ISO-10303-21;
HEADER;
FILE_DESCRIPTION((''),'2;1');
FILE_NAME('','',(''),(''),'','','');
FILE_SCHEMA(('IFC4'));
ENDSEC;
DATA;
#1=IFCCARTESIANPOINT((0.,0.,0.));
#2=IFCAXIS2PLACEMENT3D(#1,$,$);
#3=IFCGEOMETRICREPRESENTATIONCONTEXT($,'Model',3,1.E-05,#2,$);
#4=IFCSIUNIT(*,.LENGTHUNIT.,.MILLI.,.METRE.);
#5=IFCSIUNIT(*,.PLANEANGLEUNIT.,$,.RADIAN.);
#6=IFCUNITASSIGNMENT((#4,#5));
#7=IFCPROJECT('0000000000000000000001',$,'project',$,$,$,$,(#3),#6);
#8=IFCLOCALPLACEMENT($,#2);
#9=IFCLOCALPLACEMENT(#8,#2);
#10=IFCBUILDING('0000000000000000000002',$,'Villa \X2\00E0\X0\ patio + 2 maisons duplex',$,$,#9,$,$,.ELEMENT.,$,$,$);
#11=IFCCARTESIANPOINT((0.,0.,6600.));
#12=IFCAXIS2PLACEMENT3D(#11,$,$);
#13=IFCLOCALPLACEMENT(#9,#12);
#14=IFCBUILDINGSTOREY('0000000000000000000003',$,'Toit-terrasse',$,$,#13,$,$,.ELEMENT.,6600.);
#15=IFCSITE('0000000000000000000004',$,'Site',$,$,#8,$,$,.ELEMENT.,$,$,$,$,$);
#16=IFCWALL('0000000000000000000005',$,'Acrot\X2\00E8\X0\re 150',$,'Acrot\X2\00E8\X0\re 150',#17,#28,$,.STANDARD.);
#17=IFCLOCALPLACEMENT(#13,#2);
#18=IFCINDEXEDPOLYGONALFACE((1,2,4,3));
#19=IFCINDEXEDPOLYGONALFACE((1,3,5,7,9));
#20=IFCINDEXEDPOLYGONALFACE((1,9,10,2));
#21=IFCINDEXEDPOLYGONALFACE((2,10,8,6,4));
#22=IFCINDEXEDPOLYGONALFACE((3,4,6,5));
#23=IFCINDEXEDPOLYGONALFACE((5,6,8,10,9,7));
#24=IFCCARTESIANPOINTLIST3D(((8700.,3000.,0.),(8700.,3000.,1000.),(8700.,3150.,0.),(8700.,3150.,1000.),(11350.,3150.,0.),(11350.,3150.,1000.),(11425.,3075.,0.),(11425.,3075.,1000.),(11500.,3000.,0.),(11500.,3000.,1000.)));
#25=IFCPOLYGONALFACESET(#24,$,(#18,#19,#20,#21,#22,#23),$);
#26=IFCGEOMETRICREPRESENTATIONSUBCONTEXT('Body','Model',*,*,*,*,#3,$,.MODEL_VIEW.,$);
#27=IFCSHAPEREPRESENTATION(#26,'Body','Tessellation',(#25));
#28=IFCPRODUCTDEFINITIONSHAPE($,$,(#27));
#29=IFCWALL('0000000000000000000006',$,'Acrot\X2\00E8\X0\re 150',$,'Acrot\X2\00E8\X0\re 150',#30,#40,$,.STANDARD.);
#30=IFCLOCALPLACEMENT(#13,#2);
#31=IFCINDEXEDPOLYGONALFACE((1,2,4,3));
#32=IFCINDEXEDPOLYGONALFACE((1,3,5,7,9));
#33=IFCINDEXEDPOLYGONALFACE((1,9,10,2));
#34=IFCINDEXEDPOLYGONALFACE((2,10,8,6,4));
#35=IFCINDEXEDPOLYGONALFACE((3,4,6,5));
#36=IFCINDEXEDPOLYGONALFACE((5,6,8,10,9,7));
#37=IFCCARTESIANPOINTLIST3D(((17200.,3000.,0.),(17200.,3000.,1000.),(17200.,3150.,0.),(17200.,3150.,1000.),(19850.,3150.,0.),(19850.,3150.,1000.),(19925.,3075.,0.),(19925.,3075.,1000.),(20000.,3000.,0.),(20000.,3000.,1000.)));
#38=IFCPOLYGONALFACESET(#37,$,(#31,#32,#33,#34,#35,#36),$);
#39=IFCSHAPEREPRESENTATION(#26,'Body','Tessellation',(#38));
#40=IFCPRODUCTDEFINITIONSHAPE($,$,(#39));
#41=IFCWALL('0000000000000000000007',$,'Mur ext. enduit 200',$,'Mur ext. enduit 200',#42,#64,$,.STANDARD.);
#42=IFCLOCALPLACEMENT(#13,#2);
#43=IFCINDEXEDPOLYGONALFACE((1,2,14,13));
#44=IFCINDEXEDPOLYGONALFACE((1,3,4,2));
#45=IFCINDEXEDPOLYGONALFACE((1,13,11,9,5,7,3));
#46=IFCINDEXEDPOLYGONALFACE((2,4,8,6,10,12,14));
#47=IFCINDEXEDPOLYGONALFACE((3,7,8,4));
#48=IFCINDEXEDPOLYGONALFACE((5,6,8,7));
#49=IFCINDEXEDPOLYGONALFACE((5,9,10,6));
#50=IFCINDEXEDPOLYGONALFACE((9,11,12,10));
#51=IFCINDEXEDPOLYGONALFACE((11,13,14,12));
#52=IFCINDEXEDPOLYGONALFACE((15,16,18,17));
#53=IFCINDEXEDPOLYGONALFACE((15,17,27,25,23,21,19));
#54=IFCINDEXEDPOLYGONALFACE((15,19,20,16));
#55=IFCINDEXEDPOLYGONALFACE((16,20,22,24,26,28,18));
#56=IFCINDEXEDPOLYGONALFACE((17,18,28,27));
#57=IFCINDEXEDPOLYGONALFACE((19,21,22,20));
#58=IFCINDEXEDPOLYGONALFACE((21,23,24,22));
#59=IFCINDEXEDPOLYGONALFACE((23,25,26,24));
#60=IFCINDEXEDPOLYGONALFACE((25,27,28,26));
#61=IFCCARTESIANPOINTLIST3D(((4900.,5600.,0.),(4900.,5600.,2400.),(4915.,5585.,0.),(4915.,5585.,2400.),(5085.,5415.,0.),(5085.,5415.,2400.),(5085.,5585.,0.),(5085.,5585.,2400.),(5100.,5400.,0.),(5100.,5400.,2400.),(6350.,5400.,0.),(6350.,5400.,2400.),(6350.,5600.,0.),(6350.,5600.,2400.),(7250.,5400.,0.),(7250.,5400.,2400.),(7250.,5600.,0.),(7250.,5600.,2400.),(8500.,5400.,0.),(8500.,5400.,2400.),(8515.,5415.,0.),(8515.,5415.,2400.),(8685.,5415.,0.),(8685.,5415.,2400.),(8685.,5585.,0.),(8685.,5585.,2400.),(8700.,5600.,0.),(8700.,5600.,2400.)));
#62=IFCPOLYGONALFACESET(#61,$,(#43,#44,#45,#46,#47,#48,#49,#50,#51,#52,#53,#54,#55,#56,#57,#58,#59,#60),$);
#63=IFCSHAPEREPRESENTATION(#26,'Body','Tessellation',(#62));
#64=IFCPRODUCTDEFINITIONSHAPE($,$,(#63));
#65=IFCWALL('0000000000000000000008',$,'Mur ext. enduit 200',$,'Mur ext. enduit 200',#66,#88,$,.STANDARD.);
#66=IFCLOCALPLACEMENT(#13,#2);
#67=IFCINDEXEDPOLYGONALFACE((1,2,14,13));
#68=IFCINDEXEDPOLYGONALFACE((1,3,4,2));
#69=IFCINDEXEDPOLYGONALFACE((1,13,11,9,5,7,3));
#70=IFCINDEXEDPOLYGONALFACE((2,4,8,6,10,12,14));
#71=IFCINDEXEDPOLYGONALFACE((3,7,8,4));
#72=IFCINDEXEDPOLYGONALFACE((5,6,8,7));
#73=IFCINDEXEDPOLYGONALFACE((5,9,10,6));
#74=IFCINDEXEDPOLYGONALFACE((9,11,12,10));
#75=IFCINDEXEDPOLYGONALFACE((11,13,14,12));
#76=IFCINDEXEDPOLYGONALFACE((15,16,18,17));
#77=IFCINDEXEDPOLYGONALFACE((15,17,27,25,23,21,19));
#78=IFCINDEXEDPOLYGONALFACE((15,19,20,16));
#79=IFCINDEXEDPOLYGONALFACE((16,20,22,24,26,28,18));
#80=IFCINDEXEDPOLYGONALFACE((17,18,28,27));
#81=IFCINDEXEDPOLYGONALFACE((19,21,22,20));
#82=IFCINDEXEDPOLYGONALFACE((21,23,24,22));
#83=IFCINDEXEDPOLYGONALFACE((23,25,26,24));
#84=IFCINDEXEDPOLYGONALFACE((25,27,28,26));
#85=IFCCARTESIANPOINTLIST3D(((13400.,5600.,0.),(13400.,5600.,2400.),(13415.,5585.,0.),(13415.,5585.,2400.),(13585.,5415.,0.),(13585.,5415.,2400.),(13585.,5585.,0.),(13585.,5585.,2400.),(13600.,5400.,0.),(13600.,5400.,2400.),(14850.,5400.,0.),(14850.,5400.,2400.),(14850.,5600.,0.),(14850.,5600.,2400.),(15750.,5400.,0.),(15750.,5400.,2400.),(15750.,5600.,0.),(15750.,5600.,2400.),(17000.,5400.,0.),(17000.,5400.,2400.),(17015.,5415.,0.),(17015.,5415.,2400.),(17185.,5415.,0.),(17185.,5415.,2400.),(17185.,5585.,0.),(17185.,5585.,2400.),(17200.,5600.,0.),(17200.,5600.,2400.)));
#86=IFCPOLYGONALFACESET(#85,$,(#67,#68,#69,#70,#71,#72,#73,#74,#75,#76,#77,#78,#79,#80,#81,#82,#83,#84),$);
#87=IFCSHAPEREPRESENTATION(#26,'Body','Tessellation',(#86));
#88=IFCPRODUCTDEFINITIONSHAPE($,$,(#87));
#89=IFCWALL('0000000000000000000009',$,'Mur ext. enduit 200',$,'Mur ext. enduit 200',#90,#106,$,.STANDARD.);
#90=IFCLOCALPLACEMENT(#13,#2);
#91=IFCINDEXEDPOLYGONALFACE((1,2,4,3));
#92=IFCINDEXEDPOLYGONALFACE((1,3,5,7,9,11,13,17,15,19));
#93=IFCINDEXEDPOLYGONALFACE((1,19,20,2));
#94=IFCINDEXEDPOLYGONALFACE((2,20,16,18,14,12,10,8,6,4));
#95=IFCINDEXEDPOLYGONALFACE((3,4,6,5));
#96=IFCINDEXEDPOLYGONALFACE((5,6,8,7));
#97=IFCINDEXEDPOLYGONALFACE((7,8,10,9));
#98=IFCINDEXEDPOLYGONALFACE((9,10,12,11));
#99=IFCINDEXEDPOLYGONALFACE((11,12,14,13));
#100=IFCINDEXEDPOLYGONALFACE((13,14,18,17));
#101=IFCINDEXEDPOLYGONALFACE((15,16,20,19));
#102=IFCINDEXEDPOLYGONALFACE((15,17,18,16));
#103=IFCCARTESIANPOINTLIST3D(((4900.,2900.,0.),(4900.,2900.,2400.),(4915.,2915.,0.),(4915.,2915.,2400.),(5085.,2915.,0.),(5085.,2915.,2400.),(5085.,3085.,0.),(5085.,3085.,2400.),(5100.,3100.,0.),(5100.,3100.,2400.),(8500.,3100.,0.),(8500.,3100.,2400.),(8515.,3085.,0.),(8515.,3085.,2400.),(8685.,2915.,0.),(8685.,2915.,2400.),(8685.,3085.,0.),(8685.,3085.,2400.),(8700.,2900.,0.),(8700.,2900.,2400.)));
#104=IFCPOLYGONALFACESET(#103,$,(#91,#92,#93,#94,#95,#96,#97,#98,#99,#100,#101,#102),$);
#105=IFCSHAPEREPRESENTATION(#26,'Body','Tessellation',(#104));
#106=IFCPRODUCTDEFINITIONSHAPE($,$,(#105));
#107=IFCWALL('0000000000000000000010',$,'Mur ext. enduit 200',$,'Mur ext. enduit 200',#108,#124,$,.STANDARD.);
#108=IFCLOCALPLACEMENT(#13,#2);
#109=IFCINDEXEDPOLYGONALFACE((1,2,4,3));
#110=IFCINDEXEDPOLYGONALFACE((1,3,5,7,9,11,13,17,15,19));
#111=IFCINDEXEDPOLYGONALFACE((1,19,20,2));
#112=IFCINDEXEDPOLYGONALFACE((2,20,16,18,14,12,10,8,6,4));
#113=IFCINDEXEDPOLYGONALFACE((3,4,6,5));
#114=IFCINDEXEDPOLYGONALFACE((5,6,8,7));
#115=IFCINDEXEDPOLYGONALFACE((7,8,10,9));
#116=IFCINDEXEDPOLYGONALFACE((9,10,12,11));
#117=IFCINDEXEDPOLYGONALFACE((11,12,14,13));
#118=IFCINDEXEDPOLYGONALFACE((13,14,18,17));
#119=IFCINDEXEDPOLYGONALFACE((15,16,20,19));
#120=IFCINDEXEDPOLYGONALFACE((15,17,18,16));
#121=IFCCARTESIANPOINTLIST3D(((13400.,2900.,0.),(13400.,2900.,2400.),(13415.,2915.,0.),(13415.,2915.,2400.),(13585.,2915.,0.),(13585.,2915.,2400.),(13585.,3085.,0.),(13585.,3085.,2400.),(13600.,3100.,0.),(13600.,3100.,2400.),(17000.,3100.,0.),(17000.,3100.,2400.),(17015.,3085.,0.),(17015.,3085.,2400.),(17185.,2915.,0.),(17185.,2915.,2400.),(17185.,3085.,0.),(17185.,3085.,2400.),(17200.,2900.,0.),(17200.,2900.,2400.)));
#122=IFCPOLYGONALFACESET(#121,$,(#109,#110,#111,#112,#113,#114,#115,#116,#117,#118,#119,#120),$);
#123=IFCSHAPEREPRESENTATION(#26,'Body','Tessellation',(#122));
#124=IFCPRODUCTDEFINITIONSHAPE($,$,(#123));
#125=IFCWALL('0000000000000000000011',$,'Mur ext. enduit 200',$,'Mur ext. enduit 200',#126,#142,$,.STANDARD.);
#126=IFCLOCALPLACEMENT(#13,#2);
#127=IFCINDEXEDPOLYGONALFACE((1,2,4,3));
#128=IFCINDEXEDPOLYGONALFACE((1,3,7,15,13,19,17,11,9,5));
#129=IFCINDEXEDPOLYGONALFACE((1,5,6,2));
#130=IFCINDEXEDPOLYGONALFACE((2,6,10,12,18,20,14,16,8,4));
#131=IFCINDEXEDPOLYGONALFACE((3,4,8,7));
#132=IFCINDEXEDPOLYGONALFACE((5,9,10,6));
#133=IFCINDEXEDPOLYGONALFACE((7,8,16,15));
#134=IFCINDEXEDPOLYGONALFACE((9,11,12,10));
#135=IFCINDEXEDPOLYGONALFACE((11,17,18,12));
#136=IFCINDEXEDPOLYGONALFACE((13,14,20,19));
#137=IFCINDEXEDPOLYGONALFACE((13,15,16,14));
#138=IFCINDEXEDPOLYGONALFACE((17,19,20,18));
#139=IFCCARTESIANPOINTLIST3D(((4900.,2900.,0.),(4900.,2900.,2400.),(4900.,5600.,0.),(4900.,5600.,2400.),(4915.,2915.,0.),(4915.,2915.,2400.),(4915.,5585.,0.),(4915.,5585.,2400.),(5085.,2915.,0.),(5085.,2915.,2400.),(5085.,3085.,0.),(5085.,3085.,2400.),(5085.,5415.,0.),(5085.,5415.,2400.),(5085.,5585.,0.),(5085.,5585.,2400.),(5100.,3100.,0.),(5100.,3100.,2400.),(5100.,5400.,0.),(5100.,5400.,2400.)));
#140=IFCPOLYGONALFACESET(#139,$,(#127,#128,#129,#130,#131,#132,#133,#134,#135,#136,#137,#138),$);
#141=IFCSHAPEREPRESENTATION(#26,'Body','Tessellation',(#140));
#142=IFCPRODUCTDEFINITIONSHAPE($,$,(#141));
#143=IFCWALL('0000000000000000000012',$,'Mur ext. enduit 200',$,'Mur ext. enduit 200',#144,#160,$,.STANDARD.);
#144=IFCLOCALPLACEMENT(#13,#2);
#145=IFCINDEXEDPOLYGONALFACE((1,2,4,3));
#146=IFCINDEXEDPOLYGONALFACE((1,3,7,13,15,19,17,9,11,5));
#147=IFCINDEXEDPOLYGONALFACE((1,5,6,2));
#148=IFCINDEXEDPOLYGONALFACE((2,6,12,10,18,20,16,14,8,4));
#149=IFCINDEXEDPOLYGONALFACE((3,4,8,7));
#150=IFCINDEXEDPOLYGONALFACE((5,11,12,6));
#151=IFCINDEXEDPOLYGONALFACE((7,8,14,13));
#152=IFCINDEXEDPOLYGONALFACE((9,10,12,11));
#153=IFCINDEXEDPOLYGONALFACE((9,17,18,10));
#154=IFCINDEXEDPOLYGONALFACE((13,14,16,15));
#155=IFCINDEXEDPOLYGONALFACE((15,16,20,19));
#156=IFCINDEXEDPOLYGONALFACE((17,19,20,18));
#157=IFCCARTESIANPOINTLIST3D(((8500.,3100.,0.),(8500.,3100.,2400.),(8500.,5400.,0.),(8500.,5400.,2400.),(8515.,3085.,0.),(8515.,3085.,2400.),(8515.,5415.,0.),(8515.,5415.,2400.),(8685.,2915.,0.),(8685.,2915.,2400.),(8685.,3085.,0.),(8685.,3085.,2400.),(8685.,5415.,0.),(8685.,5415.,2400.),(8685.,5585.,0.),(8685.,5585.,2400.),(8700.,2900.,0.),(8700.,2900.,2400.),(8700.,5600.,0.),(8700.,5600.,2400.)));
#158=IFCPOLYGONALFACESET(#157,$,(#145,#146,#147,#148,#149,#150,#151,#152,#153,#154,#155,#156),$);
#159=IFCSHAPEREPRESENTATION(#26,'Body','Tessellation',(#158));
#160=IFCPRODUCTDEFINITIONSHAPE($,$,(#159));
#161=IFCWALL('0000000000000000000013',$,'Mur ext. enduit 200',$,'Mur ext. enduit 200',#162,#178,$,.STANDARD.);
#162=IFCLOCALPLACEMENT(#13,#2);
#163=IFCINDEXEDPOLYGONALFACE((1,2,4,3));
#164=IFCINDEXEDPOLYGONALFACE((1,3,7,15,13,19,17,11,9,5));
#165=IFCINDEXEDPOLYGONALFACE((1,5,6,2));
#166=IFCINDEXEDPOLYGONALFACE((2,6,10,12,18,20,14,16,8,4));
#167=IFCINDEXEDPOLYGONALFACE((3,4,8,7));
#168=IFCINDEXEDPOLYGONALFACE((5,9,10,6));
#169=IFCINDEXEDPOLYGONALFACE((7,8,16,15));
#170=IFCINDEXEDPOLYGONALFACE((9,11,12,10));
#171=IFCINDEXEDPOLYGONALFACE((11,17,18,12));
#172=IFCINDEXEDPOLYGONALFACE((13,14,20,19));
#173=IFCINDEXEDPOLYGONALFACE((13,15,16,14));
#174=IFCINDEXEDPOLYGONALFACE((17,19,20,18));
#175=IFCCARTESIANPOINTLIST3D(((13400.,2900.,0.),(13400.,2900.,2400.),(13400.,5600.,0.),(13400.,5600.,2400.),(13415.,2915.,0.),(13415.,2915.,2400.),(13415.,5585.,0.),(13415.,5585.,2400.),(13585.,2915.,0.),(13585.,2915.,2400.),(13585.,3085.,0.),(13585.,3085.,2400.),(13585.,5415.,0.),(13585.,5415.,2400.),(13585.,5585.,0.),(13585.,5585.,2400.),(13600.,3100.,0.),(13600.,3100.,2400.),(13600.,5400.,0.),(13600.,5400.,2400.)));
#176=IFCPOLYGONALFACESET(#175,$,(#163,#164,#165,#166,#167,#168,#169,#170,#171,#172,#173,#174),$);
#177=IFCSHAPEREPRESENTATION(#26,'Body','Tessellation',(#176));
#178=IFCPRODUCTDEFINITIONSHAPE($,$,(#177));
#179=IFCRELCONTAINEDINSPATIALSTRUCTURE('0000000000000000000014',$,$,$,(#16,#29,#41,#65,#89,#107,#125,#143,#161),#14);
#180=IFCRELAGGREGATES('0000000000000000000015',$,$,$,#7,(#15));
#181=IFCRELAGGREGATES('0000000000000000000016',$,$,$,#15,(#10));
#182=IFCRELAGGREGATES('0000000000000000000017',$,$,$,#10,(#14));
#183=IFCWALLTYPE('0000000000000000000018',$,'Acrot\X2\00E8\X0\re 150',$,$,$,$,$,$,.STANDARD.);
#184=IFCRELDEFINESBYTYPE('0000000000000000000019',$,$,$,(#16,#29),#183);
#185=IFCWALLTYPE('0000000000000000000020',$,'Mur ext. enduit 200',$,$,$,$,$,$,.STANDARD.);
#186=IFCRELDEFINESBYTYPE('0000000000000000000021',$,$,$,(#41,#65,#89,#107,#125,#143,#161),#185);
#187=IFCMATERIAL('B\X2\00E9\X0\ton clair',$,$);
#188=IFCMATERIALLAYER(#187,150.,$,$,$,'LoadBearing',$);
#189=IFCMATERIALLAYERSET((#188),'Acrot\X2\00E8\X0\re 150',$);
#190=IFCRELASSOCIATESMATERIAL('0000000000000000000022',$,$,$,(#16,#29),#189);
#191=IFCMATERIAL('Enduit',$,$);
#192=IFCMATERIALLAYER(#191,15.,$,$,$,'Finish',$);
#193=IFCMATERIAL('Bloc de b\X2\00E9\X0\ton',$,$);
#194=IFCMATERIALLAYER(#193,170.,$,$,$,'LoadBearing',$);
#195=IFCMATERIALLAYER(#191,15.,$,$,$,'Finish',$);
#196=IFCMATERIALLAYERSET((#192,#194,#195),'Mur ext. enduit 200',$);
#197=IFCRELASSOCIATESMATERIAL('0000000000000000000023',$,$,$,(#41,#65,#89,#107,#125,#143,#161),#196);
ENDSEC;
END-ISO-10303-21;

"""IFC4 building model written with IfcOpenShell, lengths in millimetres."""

from ifc_helpers import new_model, si_unit, frame, frame_2d, origin, place, context, subcontext, project, spatial, polyline, rectangle, outline, extrude, material, layer, layer_set, layer_usage, type_object, element, save


model = new_model("IFC4")

# Units and contexts
model_context = context("Model", 3, precision=1e-05, world=origin())
body_context = subcontext(model_context, "Body", "Model", "MODEL_VIEW")
ifc_project = project(units=[si_unit("LENGTHUNIT", "METRE", prefix="MILLI"), si_unit("PLANEANGLEUNIT", "RADIAN")], contexts=[model_context])

# Site, building, storey
site_placement = place(None, origin())
site = spatial("IfcSite", under=ifc_project, at=site_placement, Name="Site", CompositionType="ELEMENT")
building_placement = place(site_placement, origin())
building = spatial("IfcBuilding", under=site, at=building_placement, Name="Villa à patio + 2 maisons duplex", CompositionType="ELEMENT")
storey_placement = place(building_placement, frame((0.0, 0.0, 6600.0)))
storey = spatial("IfcBuildingStorey", under=building, at=storey_placement, Name="Toit-terrasse", CompositionType="ELEMENT", Elevation=6600.0)

# Walls
ifc_material_1 = material(Name="Béton clair")
ifc_layer_1 = layer(ifc_material_1, 150.0, Category="LoadBearing")
ifc_layer_set_1 = layer_set([ifc_layer_1], Name="Acrotère 150")
ifc_layer_usage_1 = layer_usage(ifc_layer_set_1, "AXIS2", "NEGATIVE", 75.0)
wall_type_1 = type_object("IfcWallType", Name="Acrotère 150", PredefinedType="STANDARD")
wall_1_placement = place(storey_placement, frame((11425.0, 3075.0, 0.0), z_axis=(0.0, 0.0, 1.0), x_axis=(-1.0, 0.0, 0.0)))
element("IfcWall", 1, at=wall_1_placement, inside=storey, type_object=wall_type_1, material=ifc_layer_usage_1, Name="Acrotère 150", ObjectType="Acrotère 150", PredefinedType="STANDARD", context=body_context, shape_type="SweptSolid", body=[
    extrude(outline(polyline([(75.0, -75.0), (0.0, 0.0), (-75.0, 75.0), (2725.0, 75.0), (2725.0, -75.0), (75.0, -75.0)])), origin(), (0.0, 0.0, 1.0), 1000.0),
])
wall_2_placement = place(storey_placement, frame((19925.0, 3075.0, 0.0), z_axis=(0.0, 0.0, 1.0), x_axis=(-1.0, 0.0, 0.0)))
element("IfcWall", 2, at=wall_2_placement, inside=storey, type_object=wall_type_1, material=ifc_layer_usage_1, Name="Acrotère 150", ObjectType="Acrotère 150", PredefinedType="STANDARD", context=body_context, shape_type="SweptSolid", body=[
    extrude(outline(polyline([(75.0, -75.0), (0.0, 0.0), (-75.0, 75.0), (2725.0, 75.0), (2725.0, -75.0), (75.0, -75.0)])), origin(), (0.0, 0.0, 1.0), 1000.0),
])

# Walls, openings
ifc_material_2 = material(Name="Enduit")
ifc_layer_2 = layer(ifc_material_2, 15.0, Category="Finish")
ifc_material_3 = material(Name="Bloc de béton")
ifc_layer_3 = layer(ifc_material_3, 170.0, Category="LoadBearing")
ifc_layer_4 = layer(ifc_material_2, 15.0, Category="Finish")
ifc_layer_set_2 = layer_set([ifc_layer_2, ifc_layer_3, ifc_layer_4], Name="Mur ext. enduit 200")
ifc_layer_usage_2 = layer_usage(ifc_layer_set_2, "AXIS2", "NEGATIVE", 100.0)
wall_type_2 = type_object("IfcWallType", Name="Mur ext. enduit 200", PredefinedType="STANDARD")
wall_3_placement = place(storey_placement, frame((5000.0, 5500.0, 0.0), z_axis=(0.0, 0.0, 1.0), x_axis=(1.0, 0.0, 0.0)))
wall_3 = element("IfcWall", 3, at=wall_3_placement, inside=storey, type_object=wall_type_2, material=ifc_layer_usage_2, Name="Mur ext. enduit 200", ObjectType="Mur ext. enduit 200", PredefinedType="STANDARD", context=body_context, shape_type="SweptSolid", body=[
    extrude(outline(polyline([(100.0, -100.0), (85.0, -85.0), (85.0, 85.0), (-85.0, 85.0), (-100.0, 100.0), (3700.0, 100.0), (3685.0, 85.0), (3685.0, -85.0), (3515.0, -85.0), (3500.0, -100.0), (100.0, -100.0)])), origin(), (0.0, 0.0, 1.0), 2400.0),
])
opening_1_placement = place(wall_3_placement, frame((1350.0, 0.0, 0.0), z_axis=(0.0, 0.0, 1.0), x_axis=(1.0, 0.0, 0.0)))
element("IfcOpeningElement", 4, at=opening_1_placement, cuts=wall_3, PredefinedType="OPENING", context=body_context, shape_type="SweptSolid", body=[
    extrude(rectangle(XDim=900.0, YDim=220.0, at=frame_2d((450.0, 0.0))), origin(), (0.0, 0.0, 1.0), 2400.0),
])
wall_4_placement = place(storey_placement, frame((13500.0, 5500.0, 0.0), z_axis=(0.0, 0.0, 1.0), x_axis=(1.0, 0.0, 0.0)))
wall_4 = element("IfcWall", 5, at=wall_4_placement, inside=storey, type_object=wall_type_2, material=ifc_layer_usage_2, Name="Mur ext. enduit 200", ObjectType="Mur ext. enduit 200", PredefinedType="STANDARD", context=body_context, shape_type="SweptSolid", body=[
    extrude(outline(polyline([(100.0, -100.0), (85.0, -85.0), (85.0, 85.0), (-85.0, 85.0), (-100.0, 100.0), (3700.0, 100.0), (3685.0, 85.0), (3685.0, -85.0), (3515.0, -85.0), (3500.0, -100.0), (100.0, -100.0)])), origin(), (0.0, 0.0, 1.0), 2400.0),
])
opening_2_placement = place(wall_4_placement, frame((1350.0, 0.0, 0.0), z_axis=(0.0, 0.0, 1.0), x_axis=(1.0, 0.0, 0.0)))
element("IfcOpeningElement", 6, at=opening_2_placement, cuts=wall_4, PredefinedType="OPENING", context=body_context, shape_type="SweptSolid", body=[
    extrude(rectangle(XDim=900.0, YDim=220.0, at=frame_2d((450.0, 0.0))), origin(), (0.0, 0.0, 1.0), 2400.0),
])

# Walls
for number, where, z_axis, x_axis, name in (
    (7, (5000.0, 3000.0, 0.0), (0.0, 0.0, 1.0), (1.0, 0.0, 0.0), "Mur ext. enduit 200"),
    (8, (13500.0, 3000.0, 0.0), (0.0, 0.0, 1.0), (1.0, 0.0, 0.0), "Mur ext. enduit 200"),
):
    element("IfcWall", number, at=place(storey_placement, frame(where, z_axis=z_axis, x_axis=x_axis)), inside=storey, type_object=wall_type_2, material=ifc_layer_usage_2, Name=name, ObjectType="Mur ext. enduit 200", PredefinedType="STANDARD", context=body_context, shape_type="SweptSolid", body=[
        extrude(outline(polyline([(-100.0, -100.0), (-85.0, -85.0), (85.0, -85.0), (85.0, 85.0), (100.0, 100.0), (3500.0, 100.0), (3515.0, 85.0), (3685.0, 85.0), (3685.0, -85.0), (3700.0, -100.0), (-100.0, -100.0)])), origin(), (0.0, 0.0, 1.0), 2400.0),
    ])
wall_5_placement = place(storey_placement, frame((5000.0, 5500.0, 0.0), z_axis=(0.0, 0.0, 1.0), x_axis=(0.0, -1.0, 0.0)))
element("IfcWall", 9, at=wall_5_placement, inside=storey, type_object=wall_type_2, material=ifc_layer_usage_2, Name="Mur ext. enduit 200", ObjectType="Mur ext. enduit 200", PredefinedType="STANDARD", context=body_context, shape_type="SweptSolid", body=[
    extrude(outline(polyline([(-100.0, -100.0), (-85.0, -85.0), (-85.0, 85.0), (85.0, 85.0), (100.0, 100.0), (2400.0, 100.0), (2415.0, 85.0), (2585.0, 85.0), (2585.0, -85.0), (2600.0, -100.0), (-100.0, -100.0)])), origin(), (0.0, 0.0, 1.0), 2400.0),
])
wall_6_placement = place(storey_placement, frame((8600.0, 5500.0, 0.0), z_axis=(0.0, 0.0, 1.0), x_axis=(0.0, -1.0, 0.0)))
element("IfcWall", 10, at=wall_6_placement, inside=storey, type_object=wall_type_2, material=ifc_layer_usage_2, Name="Mur ext. enduit 200", ObjectType="Mur ext. enduit 200", PredefinedType="STANDARD", context=body_context, shape_type="SweptSolid", body=[
    extrude(outline(polyline([(100.0, -100.0), (85.0, -85.0), (85.0, 85.0), (-85.0, 85.0), (-100.0, 100.0), (2600.0, 100.0), (2585.0, 85.0), (2415.0, 85.0), (2415.0, -85.0), (2400.0, -100.0), (100.0, -100.0)])), origin(), (0.0, 0.0, 1.0), 2400.0),
])
wall_7_placement = place(storey_placement, frame((13500.0, 5500.0, 0.0), z_axis=(0.0, 0.0, 1.0), x_axis=(0.0, -1.0, 0.0)))
element("IfcWall", 11, at=wall_7_placement, inside=storey, type_object=wall_type_2, material=ifc_layer_usage_2, Name="Mur ext. enduit 200", ObjectType="Mur ext. enduit 200", PredefinedType="STANDARD", context=body_context, shape_type="SweptSolid", body=[
    extrude(outline(polyline([(-100.0, -100.0), (-85.0, -85.0), (-85.0, 85.0), (85.0, 85.0), (100.0, 100.0), (2400.0, 100.0), (2415.0, 85.0), (2585.0, 85.0), (2585.0, -85.0), (2600.0, -100.0), (-100.0, -100.0)])), origin(), (0.0, 0.0, 1.0), 2400.0),
])

save(model, "model.ifc")
